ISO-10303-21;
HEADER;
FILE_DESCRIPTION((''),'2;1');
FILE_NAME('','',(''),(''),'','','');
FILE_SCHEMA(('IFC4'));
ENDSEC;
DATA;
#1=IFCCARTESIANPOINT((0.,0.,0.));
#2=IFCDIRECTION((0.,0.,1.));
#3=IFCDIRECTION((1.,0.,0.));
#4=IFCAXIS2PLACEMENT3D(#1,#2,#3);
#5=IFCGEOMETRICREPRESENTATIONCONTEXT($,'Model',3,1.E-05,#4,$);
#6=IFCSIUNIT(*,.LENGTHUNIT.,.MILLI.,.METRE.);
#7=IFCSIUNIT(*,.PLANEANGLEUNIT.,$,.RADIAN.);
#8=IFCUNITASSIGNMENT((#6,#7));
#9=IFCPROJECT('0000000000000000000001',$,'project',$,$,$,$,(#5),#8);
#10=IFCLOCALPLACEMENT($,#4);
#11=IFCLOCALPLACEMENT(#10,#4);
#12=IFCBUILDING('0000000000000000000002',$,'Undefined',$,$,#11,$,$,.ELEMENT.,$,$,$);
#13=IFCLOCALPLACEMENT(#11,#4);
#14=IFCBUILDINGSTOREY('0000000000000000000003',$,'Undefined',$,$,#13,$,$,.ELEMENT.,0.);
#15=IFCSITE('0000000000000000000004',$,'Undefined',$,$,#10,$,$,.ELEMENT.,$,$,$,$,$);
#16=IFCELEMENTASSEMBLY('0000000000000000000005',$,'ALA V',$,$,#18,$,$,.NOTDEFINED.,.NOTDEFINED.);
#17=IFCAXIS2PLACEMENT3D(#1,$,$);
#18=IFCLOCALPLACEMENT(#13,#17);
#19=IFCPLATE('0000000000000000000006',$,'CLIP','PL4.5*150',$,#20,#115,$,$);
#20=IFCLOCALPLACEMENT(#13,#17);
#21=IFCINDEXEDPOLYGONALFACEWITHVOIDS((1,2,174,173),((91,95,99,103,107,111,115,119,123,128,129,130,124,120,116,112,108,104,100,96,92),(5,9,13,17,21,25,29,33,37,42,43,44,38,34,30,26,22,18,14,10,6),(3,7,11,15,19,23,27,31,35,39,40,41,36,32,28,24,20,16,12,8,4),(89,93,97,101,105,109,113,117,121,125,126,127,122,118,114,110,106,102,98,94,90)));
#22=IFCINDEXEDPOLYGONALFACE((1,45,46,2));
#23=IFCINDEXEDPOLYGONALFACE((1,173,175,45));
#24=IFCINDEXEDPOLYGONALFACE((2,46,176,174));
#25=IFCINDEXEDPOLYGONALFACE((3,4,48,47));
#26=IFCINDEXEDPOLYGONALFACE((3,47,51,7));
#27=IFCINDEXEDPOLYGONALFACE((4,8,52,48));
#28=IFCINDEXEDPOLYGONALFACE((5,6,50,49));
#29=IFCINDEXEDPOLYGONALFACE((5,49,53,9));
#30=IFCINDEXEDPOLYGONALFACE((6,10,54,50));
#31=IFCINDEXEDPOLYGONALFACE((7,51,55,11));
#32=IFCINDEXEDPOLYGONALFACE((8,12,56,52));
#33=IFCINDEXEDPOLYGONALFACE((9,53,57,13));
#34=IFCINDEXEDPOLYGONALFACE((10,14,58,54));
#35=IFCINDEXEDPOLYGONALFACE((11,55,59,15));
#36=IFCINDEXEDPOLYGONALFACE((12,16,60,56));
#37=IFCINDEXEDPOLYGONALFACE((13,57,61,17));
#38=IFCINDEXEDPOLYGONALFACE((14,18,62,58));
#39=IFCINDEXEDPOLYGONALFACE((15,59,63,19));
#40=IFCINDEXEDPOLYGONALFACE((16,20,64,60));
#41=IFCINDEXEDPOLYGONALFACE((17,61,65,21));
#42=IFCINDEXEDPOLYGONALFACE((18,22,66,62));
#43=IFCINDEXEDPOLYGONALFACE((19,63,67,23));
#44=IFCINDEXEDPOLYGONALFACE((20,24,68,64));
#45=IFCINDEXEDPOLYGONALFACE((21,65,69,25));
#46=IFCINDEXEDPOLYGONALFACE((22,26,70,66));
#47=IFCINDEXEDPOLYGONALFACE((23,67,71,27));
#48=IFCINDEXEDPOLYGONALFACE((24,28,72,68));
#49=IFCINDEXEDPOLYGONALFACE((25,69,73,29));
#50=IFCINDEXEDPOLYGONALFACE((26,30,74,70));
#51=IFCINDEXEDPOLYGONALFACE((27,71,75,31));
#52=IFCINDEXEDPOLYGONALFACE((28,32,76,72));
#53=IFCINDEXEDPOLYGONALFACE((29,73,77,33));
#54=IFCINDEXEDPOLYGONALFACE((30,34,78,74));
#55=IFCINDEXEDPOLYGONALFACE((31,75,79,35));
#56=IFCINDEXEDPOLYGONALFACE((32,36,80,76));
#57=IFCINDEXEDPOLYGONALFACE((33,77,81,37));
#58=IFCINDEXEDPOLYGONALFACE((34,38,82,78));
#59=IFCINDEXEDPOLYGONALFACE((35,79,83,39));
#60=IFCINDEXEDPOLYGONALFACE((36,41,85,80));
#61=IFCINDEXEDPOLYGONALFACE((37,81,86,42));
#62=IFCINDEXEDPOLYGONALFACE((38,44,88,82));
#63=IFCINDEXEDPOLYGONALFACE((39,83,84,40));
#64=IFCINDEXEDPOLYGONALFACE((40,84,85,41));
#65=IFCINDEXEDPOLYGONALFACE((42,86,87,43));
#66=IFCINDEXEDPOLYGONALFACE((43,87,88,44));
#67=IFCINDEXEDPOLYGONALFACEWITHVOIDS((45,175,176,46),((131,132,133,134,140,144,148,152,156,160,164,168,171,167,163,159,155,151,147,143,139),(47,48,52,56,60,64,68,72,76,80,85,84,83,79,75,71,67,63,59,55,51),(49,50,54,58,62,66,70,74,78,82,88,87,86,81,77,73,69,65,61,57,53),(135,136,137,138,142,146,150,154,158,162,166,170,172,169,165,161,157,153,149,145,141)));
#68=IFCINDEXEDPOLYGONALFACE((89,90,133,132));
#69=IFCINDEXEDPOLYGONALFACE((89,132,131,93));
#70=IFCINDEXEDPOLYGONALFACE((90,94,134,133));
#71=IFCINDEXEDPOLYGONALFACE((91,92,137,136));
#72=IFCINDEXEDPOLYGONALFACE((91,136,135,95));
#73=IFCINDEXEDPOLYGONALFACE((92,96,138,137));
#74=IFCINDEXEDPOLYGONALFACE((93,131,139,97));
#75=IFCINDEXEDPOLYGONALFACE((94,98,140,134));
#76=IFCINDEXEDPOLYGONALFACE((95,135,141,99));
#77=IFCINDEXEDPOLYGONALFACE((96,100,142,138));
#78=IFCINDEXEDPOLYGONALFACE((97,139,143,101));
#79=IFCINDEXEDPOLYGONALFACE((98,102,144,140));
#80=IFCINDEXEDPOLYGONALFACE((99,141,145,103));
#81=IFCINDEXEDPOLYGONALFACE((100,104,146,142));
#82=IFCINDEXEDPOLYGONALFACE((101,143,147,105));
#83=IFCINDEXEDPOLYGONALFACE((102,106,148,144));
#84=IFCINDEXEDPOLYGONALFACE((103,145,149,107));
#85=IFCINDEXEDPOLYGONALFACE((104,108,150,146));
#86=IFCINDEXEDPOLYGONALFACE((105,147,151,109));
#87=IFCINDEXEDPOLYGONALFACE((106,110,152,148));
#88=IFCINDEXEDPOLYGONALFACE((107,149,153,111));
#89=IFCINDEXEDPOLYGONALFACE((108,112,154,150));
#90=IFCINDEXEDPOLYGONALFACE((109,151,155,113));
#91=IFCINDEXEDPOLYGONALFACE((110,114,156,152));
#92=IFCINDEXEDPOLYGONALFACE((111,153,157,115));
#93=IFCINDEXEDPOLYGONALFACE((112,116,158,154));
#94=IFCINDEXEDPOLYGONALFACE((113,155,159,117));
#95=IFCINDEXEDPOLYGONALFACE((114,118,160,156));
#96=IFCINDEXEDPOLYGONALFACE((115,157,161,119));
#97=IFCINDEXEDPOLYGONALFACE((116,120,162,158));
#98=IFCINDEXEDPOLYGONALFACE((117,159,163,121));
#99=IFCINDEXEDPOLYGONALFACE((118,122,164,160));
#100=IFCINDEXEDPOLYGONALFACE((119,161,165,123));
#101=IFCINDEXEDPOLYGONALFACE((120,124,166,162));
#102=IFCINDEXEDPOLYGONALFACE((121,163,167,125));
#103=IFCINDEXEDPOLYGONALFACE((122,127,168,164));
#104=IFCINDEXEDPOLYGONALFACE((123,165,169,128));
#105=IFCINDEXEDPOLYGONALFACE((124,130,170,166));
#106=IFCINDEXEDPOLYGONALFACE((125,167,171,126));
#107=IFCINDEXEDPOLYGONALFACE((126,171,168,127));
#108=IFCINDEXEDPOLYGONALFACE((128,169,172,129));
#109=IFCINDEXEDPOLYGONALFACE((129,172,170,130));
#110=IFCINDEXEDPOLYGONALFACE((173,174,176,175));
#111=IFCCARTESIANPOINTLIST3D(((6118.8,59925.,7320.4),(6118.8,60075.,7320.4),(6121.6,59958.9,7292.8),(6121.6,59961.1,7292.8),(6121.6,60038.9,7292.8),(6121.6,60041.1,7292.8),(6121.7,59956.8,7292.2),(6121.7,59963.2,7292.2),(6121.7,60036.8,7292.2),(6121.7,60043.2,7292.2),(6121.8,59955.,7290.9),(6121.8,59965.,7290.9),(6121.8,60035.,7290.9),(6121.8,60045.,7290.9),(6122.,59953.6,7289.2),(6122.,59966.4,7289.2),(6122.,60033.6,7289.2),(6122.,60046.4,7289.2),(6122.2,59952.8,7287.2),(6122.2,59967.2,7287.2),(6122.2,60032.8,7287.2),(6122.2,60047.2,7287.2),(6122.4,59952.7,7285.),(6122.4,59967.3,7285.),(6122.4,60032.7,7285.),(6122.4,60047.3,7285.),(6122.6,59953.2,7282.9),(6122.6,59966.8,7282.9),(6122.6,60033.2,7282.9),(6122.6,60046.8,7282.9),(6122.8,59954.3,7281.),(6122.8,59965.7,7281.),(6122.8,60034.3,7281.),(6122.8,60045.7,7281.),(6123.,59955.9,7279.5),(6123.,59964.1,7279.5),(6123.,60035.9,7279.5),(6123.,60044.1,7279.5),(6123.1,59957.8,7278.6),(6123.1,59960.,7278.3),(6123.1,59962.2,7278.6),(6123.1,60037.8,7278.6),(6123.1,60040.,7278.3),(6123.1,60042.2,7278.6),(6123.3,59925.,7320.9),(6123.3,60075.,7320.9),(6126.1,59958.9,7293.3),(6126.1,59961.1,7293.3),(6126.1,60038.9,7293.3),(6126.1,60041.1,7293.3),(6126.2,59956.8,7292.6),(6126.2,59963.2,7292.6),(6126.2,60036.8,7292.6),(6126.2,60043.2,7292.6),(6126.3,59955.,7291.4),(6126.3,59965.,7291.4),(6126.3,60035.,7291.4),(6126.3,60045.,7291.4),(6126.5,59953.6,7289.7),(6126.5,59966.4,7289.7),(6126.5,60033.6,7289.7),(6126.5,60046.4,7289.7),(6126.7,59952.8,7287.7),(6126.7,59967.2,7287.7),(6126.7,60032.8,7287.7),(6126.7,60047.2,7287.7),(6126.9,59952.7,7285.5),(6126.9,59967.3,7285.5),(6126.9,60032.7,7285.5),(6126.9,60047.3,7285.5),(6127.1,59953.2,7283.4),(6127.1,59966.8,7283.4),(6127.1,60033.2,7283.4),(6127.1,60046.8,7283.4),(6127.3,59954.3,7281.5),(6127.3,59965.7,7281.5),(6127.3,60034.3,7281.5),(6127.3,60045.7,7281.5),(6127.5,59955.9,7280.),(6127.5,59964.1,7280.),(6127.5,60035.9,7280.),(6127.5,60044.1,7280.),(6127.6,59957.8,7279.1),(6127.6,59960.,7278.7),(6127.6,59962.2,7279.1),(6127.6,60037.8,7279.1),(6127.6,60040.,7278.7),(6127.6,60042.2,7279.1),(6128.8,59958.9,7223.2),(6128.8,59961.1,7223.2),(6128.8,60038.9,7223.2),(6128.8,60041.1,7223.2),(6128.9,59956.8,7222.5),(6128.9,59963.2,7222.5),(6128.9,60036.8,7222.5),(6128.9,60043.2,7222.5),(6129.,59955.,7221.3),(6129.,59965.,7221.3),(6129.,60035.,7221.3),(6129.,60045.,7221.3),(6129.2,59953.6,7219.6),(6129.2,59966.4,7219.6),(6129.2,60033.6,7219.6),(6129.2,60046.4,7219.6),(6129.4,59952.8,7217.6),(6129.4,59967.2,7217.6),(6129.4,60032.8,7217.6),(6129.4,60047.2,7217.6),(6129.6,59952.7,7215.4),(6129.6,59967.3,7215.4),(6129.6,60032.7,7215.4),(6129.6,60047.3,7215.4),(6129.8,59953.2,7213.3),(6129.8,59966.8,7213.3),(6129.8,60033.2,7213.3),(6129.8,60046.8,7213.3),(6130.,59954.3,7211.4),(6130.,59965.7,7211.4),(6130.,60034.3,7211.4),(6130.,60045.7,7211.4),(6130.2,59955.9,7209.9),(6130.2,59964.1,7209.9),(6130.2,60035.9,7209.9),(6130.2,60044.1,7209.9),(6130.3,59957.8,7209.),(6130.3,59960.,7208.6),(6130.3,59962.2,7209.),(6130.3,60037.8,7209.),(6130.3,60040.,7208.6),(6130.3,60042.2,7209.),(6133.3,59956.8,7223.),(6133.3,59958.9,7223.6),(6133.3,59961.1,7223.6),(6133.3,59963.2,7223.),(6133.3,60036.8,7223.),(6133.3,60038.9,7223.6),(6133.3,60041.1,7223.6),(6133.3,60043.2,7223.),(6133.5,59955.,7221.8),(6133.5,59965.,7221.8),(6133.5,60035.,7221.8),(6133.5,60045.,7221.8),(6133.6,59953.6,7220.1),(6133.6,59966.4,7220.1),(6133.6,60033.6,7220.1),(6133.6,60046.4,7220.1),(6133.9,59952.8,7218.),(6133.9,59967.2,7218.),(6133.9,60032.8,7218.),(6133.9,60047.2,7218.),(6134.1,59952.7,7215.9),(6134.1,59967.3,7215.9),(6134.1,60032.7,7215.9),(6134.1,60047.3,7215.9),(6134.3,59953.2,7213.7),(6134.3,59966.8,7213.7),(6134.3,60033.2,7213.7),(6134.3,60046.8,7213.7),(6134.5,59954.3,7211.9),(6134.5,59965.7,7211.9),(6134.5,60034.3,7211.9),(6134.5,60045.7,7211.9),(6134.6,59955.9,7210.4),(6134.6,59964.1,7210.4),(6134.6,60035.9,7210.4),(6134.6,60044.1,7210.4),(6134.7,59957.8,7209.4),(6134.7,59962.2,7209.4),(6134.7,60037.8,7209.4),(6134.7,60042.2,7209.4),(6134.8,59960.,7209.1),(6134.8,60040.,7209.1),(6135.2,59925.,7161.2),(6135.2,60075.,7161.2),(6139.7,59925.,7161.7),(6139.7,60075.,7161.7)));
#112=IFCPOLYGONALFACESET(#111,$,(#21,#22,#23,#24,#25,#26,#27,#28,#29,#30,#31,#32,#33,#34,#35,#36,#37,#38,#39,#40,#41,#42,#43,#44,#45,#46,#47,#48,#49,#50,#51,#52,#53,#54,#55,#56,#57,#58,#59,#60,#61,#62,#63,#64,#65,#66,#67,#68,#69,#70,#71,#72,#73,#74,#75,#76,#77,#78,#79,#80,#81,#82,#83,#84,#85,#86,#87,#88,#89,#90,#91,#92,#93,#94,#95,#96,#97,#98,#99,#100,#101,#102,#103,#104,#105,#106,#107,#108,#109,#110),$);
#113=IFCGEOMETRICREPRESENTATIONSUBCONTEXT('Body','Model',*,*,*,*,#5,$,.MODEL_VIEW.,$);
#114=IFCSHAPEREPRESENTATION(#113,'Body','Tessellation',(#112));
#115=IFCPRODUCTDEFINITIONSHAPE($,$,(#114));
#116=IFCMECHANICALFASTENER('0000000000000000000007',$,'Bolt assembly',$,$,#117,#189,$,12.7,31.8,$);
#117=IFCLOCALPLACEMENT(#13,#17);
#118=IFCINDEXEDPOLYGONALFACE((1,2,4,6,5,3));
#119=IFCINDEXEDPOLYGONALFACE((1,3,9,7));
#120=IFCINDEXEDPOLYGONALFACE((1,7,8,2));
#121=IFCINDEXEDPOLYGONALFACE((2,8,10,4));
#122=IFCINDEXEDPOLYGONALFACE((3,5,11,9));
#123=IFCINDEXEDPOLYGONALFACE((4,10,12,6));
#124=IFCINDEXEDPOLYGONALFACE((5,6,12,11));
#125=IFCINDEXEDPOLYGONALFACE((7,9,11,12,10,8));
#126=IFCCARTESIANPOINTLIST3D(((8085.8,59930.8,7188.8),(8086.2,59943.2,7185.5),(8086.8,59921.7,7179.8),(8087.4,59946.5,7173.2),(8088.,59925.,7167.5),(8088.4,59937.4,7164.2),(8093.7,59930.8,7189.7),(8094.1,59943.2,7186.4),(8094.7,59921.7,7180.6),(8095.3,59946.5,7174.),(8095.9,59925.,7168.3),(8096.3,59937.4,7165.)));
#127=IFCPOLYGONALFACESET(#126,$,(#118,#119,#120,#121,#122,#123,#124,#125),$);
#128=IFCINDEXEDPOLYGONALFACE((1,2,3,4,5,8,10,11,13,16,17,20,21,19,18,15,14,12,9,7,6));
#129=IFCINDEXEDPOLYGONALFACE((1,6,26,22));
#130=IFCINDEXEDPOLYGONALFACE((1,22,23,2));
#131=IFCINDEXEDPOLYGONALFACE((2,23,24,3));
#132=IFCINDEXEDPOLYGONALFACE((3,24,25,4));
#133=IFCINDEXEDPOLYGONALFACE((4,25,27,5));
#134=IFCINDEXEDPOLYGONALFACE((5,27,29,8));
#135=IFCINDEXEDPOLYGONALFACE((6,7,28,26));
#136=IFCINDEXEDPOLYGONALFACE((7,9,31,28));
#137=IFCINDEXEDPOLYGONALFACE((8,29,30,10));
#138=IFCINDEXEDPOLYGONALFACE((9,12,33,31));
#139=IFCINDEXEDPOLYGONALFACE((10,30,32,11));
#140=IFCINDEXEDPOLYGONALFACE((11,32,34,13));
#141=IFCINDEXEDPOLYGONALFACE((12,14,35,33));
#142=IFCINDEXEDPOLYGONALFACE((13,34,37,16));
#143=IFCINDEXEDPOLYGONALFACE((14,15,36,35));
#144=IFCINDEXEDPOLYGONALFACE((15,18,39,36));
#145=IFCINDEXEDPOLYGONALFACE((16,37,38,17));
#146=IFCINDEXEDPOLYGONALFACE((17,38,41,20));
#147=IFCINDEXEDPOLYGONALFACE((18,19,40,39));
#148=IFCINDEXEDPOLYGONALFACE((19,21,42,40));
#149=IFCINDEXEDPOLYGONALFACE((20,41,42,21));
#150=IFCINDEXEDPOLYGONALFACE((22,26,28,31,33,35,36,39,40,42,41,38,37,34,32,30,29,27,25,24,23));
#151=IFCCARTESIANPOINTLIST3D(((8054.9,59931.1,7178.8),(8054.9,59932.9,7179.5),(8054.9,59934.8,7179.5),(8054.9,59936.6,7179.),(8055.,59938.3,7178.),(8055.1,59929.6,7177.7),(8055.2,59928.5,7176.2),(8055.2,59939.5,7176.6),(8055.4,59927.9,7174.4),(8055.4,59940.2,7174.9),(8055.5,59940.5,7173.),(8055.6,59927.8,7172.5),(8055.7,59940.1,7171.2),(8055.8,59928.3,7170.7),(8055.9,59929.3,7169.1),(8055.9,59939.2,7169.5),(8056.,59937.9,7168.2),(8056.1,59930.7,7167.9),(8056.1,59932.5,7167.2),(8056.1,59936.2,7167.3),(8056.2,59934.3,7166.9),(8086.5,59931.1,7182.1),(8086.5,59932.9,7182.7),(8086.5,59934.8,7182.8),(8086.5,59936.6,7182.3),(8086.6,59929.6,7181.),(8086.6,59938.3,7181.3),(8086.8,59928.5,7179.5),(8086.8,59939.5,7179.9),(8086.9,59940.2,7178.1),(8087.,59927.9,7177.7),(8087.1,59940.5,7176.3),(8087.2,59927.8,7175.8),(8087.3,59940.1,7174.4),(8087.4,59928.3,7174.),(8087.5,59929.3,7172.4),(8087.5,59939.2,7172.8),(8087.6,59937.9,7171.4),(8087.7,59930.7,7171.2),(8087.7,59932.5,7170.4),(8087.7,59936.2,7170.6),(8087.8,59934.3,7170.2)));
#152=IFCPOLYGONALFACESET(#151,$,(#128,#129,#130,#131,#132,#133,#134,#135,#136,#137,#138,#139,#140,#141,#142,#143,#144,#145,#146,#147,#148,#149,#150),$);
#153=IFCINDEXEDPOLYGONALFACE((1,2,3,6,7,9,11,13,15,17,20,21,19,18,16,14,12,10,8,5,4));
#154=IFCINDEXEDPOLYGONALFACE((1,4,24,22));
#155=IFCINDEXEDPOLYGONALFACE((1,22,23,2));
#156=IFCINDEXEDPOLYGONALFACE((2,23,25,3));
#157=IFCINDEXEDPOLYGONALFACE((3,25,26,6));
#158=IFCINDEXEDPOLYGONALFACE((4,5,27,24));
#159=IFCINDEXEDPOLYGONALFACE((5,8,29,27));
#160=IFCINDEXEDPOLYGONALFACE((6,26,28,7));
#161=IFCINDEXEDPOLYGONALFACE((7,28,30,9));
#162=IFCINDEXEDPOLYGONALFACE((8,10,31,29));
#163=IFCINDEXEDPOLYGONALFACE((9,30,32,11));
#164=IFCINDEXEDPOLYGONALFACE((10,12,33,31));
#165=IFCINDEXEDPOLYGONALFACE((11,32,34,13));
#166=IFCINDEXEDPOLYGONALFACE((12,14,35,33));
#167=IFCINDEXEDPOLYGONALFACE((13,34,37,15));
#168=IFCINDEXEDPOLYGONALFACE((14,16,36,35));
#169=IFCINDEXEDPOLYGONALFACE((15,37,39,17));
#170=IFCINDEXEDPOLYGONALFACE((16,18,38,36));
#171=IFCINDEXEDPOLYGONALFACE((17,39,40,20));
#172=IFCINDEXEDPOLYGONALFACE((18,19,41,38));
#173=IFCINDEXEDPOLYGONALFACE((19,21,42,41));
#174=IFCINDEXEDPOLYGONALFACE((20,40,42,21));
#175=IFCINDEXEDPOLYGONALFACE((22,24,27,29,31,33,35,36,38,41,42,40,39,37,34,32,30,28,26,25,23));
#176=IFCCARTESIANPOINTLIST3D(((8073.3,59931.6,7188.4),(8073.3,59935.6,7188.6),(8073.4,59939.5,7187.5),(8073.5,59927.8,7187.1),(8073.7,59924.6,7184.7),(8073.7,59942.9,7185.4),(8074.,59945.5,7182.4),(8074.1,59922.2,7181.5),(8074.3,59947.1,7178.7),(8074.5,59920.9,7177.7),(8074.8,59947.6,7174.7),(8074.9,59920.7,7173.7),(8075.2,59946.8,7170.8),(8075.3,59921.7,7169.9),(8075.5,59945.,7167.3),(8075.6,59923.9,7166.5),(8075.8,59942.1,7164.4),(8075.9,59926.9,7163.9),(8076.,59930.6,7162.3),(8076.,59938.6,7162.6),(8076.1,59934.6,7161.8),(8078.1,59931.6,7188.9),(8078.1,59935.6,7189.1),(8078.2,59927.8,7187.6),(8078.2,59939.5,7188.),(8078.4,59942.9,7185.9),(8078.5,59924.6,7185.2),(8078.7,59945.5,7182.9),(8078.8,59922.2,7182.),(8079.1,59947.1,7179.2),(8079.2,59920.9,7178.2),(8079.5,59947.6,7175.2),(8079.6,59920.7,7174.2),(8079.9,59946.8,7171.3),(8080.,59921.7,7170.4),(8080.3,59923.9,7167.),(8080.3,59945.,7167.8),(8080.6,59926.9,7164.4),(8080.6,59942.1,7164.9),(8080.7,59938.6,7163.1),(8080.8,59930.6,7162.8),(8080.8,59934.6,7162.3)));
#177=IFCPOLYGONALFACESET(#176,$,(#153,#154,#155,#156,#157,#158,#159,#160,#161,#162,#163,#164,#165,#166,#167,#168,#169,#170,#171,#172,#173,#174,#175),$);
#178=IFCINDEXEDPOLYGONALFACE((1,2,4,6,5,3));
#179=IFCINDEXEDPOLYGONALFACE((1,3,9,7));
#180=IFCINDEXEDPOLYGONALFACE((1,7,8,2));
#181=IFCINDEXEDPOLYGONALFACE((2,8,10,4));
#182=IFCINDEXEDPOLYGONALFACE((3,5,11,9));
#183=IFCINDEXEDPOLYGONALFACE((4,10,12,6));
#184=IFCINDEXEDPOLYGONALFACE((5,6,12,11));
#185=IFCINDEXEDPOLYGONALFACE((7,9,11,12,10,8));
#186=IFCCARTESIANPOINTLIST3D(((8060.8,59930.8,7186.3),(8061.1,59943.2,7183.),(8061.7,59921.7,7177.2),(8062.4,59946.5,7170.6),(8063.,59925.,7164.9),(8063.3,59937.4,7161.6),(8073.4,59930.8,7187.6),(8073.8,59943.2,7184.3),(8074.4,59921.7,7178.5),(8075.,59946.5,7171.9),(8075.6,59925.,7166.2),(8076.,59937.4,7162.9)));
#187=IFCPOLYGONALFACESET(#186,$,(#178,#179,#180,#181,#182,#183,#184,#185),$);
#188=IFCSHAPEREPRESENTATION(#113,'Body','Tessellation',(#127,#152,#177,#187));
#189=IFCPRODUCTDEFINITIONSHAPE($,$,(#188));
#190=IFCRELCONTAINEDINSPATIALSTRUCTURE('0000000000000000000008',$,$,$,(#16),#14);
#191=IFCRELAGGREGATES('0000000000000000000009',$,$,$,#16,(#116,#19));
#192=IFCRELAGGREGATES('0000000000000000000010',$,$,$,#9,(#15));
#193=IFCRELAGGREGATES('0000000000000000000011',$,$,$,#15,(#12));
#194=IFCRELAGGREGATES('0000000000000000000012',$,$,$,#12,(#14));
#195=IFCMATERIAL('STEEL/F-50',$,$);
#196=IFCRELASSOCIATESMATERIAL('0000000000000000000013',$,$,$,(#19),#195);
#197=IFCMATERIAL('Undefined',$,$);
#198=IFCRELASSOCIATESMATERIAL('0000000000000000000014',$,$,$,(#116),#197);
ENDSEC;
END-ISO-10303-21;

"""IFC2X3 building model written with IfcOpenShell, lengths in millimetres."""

from ifc_helpers import new_model, si_unit, frame, origin_with_axes, origin_2d_with_axis, place, context, subcontext, project, spatial, polyline, circle, outline, extrude, source, transform, mapped, material, element, aggregate, save


model = new_model("IFC2X3")

# Units and contexts
model_context = context("Model", 3, precision=1e-05, world=origin_with_axes())
body_context = subcontext(model_context, "Body", "Model", "MODEL_VIEW")
ifc_project = project(units=[si_unit("LENGTHUNIT", "METRE", prefix="MILLI"), si_unit("PLANEANGLEUNIT", "RADIAN")], contexts=[model_context])

# Site, building, storey
site_placement = place(None, origin_with_axes())
site = spatial("IfcSite", under=ifc_project, at=site_placement, Name="Undefined", CompositionType="ELEMENT")
building_placement = place(site_placement, origin_with_axes())
building = spatial("IfcBuilding", under=site, at=building_placement, Name="Undefined", CompositionType="ELEMENT")
storey_placement = place(building_placement, origin_with_axes())
storey = spatial("IfcBuildingStorey", under=building, at=storey_placement, Name="Undefined", CompositionType="ELEMENT", Elevation=0.0)

# Element assembly
assembly_1_placement = place(storey_placement, origin_with_axes())
assembly_1 = element("IfcElementAssembly", 1, at=assembly_1_placement, inside=storey, Name="ALA V", AssemblyPlace="NOTDEFINED", PredefinedType="NOTDEFINED")
ifc_material_1 = material(Name="STEEL/F-50")

# Plate, openings
plate_1_placement = place(assembly_1_placement, frame((6121.0, 59925.0, 7320.6), z_axis=(0.994727, 0.0, 0.102562), x_axis=(0.102562, 0.0, -0.994727)))
plate_1 = element("IfcPlate", 2, at=plate_1_placement, material=ifc_material_1, Name="CLIP", Description="PL4.5*150", context=body_context, shape_type="SweptSolid", body=[
    extrude(outline(polyline([(0.0, 0.0), (160.0, 0.0), (160.0, 150.0), (0.0, 150.0), (0.0, 0.0)])), frame((0.0, 0.0, -2.2), z_axis=(0.0, 0.0, 1.0), x_axis=(1.0, 0.0, 0.0)), (0.0, 0.0, 1.0), 4.5),
])
shared_shape_1 = source(origin_with_axes(), body_context, "Body", "SweptSolid", [
    extrude(circle(Radius=7.3, at=origin_2d_with_axis()), frame((0.0, -4.6, 0.0), z_axis=(0.0, 1.0, 0.0), x_axis=(1.0, 0.0, 0.0)), (0.0, 0.0, 1.0), 4.7),
])
opening_1_placement = place(assembly_1_placement, frame((6122.4, 60040.0, 7285.6), z_axis=(0.0, 1.0, 0.0), x_axis=(0.102562, 0.0, -0.994727)))
element("IfcOpeningElement", 3, at=opening_1_placement, cuts=plate_1, ObjectType="Opening", context=body_context, shape_type="MappedRepresentation", body=[
    mapped(shared_shape_1, transform((0.0, 0.0, 0.0))),
    mapped(shared_shape_1, transform((70.0, 0.0, 0.0))),
])
opening_2_placement = place(assembly_1_placement, frame((6122.4, 59960.0, 7285.6), z_axis=(0.0, 1.0, 0.0), x_axis=(0.102562, 0.0, -0.994727)))
element("IfcOpeningElement", 4, at=opening_2_placement, cuts=plate_1, ObjectType="Opening", context=body_context, shape_type="MappedRepresentation", body=[
    mapped(shared_shape_1, transform((0.0, 0.0, 0.0))),
    mapped(shared_shape_1, transform((70.0, 0.0, 0.0))),
])

# Mechanical fastener
ifc_material_2 = material(Name="Undefined")
shared_shape_2 = source(origin_with_axes(), body_context, "Body", "SweptSolid", [
    extrude(outline(polyline([(11.1, -6.4), (11.1, 6.4), (0.0, 12.8), (-11.1, 6.4), (-11.1, -6.4), (0.0, -12.8), (11.1, -6.4)])), frame((0.0, -11.1, 0.0), z_axis=(0.0, 1.0, 0.0), x_axis=(1.0, 0.0, 0.0)), (0.0, 0.0, 1.0), 7.9),
    extrude(circle(Radius=6.3, at=origin_2d_with_axis()), frame((0.0, -3.2, 0.0), z_axis=(0.0, 1.0, 0.0), x_axis=(1.0, 0.0, 0.0)), (0.0, 0.0, 1.0), 31.8),
    extrude(circle(Radius=13.5, at=origin_2d_with_axis()), frame((0.0, 4.5, 0.0), z_axis=(0.0, 1.0, 0.0), x_axis=(1.0, 0.0, 0.0)), (0.0, 0.0, 1.0), 4.8),
    extrude(outline(polyline([(11.1, -6.4), (11.1, 6.4), (0.0, 12.8), (-11.1, 6.4), (-11.1, -6.4), (0.0, -12.8), (11.1, -6.4)])), frame((0.0, 9.3, 0.0), z_axis=(0.0, 1.0, 0.0), x_axis=(1.0, 0.0, 0.0)), (0.0, 0.0, 1.0), 12.7),
])
mechanical_fastener_1_placement = place(assembly_1_placement, frame((8083.9, 59934.1, 7176.2), z_axis=(0.072522, -0.707107, -0.703378), x_axis=(-0.072522, -0.707107, 0.703378)))
mechanical_fastener_1 = element("IfcMechanicalFastener", 5, at=mechanical_fastener_1_placement, material=ifc_material_2, Name="Bolt assembly", NominalDiameter=12.7, NominalLength=31.8, context=body_context, shape_type="MappedRepresentation", body=[
    mapped(shared_shape_2, transform((0.0, 0.0, 0.0))),
])
aggregate(assembly_1, [mechanical_fastener_1, plate_1])

save(model, "model.ifc")
